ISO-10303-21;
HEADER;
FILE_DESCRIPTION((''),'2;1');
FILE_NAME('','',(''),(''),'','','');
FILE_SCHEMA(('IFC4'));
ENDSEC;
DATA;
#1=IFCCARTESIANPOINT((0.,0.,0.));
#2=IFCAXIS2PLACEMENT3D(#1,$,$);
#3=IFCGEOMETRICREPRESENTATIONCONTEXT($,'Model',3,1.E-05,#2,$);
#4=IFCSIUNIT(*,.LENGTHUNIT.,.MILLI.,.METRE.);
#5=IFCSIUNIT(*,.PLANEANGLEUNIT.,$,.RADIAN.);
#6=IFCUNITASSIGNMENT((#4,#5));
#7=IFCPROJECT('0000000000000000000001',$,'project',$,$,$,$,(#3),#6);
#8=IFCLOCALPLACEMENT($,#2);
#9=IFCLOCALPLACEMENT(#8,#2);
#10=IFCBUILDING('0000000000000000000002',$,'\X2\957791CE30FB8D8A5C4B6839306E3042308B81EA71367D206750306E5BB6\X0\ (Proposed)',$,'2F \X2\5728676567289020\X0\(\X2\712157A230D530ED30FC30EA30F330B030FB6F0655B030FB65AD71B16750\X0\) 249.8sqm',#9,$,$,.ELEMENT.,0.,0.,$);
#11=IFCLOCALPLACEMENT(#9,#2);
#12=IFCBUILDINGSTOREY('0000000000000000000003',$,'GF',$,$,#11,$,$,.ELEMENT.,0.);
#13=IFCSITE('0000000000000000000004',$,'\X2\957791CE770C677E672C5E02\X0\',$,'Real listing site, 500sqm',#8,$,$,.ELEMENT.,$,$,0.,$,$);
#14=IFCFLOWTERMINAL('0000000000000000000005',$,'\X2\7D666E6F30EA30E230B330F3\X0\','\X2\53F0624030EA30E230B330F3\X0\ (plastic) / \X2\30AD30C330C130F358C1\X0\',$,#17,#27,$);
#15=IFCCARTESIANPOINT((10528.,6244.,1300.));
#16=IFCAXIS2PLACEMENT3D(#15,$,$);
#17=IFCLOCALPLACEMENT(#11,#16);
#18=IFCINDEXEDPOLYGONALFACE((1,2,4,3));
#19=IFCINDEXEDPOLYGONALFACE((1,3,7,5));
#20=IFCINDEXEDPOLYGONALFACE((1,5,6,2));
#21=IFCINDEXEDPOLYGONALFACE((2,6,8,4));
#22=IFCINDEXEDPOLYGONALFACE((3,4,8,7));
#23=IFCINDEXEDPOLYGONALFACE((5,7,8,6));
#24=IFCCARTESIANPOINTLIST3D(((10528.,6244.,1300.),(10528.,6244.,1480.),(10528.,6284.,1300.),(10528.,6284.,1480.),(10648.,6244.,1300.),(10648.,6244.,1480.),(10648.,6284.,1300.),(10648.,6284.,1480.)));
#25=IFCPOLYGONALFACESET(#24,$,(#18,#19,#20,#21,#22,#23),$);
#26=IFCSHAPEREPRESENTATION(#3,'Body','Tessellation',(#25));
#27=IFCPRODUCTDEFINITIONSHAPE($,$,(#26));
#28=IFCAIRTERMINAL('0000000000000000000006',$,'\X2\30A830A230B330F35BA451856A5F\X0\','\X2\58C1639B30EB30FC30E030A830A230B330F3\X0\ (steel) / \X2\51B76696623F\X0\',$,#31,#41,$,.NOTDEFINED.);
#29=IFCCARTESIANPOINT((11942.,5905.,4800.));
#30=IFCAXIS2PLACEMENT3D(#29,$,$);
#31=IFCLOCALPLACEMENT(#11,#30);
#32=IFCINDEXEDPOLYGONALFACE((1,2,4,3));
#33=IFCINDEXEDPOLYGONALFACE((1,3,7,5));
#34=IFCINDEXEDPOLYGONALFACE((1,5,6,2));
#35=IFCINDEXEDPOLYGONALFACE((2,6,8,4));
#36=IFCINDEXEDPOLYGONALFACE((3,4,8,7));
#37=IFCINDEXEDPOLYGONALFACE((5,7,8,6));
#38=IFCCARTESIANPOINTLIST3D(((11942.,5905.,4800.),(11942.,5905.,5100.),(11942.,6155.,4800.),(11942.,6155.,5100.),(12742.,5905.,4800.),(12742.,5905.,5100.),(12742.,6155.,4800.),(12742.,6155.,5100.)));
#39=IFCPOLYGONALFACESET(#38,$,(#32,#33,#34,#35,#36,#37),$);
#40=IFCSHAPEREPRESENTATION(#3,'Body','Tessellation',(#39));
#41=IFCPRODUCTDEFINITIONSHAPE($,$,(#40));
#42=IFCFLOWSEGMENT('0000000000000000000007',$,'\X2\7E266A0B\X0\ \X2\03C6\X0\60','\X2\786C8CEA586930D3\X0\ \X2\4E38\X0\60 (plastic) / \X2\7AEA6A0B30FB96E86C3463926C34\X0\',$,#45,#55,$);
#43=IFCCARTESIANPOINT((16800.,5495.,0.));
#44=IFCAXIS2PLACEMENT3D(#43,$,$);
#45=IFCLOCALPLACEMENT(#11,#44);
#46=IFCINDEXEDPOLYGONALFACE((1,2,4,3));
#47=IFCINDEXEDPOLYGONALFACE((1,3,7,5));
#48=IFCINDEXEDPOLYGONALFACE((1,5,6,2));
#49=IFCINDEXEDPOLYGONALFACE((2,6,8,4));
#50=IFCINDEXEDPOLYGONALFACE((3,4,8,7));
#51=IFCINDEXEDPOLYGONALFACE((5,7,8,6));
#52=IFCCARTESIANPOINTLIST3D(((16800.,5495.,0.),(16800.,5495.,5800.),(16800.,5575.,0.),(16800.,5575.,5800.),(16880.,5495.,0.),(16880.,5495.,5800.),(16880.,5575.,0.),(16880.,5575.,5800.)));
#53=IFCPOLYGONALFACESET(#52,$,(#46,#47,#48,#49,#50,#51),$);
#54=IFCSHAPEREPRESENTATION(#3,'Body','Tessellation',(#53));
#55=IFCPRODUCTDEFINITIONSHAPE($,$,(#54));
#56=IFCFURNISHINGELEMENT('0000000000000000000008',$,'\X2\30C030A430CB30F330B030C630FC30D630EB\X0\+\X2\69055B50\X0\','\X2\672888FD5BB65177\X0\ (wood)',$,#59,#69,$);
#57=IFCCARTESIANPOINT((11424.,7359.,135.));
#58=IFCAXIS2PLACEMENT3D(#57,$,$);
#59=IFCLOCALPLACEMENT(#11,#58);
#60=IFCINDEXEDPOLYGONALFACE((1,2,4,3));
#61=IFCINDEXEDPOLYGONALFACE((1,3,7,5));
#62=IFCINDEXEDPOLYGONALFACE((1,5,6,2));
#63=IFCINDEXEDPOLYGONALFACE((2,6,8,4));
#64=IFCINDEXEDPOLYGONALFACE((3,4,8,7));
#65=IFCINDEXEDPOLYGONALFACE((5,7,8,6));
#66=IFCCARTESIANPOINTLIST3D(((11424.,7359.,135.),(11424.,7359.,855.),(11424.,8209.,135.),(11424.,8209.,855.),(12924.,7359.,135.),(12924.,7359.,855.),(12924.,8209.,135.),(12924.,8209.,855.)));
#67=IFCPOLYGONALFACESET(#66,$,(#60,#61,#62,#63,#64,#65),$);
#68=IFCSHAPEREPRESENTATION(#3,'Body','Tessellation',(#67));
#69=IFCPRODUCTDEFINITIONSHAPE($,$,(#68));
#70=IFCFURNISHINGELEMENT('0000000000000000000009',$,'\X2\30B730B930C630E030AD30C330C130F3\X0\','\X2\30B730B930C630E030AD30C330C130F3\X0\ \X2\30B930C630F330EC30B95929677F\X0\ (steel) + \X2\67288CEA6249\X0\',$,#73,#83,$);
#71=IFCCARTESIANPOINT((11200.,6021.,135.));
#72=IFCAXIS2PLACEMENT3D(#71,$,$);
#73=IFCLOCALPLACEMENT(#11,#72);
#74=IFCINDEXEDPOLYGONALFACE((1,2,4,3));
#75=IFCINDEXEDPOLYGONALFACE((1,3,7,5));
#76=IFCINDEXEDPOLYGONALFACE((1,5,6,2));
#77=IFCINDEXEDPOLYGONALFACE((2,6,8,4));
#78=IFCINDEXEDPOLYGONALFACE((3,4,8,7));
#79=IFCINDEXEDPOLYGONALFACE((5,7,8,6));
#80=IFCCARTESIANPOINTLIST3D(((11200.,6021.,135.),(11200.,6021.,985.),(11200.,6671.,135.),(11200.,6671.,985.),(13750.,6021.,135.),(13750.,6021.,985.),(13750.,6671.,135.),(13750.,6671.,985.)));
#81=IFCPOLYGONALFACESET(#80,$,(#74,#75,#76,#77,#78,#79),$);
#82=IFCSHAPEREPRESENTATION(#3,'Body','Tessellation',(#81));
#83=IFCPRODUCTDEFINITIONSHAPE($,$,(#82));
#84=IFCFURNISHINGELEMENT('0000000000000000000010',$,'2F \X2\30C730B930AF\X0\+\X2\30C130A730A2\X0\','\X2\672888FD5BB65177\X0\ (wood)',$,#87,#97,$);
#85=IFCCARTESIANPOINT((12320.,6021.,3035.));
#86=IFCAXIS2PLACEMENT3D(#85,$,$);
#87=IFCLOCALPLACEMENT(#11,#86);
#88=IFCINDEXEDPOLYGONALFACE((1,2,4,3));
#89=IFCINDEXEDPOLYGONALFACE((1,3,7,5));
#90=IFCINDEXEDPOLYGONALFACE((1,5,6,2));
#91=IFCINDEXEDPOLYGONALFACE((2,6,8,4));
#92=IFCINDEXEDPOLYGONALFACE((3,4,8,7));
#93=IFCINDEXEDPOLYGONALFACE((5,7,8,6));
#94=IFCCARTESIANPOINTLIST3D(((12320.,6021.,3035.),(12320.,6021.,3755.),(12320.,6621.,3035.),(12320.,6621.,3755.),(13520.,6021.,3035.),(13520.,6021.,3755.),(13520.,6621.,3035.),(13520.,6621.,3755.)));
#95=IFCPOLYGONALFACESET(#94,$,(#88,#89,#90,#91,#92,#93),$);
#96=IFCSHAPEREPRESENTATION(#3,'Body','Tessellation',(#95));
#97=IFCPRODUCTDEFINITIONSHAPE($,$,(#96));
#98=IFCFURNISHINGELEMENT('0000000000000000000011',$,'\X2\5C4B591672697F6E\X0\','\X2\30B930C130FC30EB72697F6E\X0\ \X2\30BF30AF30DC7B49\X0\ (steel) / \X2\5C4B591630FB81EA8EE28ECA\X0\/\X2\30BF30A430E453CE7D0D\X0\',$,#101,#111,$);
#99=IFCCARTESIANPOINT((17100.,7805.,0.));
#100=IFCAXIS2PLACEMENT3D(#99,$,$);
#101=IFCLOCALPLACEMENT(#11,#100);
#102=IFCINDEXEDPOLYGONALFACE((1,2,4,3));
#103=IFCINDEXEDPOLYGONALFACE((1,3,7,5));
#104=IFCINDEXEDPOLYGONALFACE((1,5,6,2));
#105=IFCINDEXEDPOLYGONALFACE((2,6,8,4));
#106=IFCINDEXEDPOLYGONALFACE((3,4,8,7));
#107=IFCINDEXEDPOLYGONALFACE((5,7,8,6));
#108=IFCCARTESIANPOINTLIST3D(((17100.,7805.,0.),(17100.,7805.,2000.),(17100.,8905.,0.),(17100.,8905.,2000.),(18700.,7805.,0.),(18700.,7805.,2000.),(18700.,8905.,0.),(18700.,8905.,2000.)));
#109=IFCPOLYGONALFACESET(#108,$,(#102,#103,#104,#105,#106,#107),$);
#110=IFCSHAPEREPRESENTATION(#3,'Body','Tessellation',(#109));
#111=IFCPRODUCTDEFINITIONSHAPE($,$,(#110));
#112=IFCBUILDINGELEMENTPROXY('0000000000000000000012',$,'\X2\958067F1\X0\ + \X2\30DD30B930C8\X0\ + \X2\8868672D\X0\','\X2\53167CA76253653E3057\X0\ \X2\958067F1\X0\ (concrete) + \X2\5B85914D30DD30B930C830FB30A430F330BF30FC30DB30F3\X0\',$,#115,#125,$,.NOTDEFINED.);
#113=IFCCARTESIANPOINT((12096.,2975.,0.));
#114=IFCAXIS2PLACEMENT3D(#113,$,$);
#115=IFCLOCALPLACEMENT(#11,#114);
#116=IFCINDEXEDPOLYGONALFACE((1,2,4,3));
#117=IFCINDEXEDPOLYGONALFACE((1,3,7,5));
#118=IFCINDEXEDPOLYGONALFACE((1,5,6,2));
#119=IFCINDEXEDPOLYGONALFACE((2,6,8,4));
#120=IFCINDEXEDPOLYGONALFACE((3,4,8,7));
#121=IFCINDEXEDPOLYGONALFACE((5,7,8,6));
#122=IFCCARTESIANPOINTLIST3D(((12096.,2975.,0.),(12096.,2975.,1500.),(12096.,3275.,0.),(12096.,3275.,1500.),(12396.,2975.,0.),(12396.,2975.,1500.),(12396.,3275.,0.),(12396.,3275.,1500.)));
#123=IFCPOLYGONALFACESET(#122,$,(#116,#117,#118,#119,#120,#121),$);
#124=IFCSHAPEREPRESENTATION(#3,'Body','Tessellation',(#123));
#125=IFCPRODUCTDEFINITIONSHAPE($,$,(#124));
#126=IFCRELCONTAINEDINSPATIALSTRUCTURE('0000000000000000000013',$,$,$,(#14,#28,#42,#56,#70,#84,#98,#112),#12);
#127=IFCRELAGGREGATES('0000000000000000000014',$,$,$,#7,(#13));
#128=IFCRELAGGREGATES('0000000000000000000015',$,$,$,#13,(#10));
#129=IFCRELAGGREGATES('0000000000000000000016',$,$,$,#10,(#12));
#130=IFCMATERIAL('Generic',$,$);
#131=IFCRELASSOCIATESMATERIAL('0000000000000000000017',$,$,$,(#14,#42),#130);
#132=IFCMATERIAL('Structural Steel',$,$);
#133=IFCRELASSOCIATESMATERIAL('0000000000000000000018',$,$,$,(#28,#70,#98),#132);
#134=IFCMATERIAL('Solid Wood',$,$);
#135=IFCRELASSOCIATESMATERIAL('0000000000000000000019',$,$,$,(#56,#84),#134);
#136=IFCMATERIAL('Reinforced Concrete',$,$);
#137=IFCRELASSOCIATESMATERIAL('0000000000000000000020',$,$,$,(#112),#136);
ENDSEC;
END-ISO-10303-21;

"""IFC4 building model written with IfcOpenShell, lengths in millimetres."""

from ifc_helpers import new_model, si_unit, frame, frame_2d, origin, place, context, project, spatial, rectangle, extrude, material, element, save


model = new_model("IFC4")

# Units and contexts
model_context = context("Model", 3, precision=1e-05, world=origin())
ifc_project = project(units=[si_unit("LENGTHUNIT", "METRE", prefix="MILLI"), si_unit("PLANEANGLEUNIT", "RADIAN")], contexts=[model_context])

# Site, building, storey
site_placement = place(None, origin())
site = spatial("IfcSite", under=ifc_project, at=site_placement, Name="長野県松本市", ObjectType="Real listing site, 500sqm", CompositionType="ELEMENT", RefElevation=0.0)
building_placement = place(site_placement, origin())
building = spatial("IfcBuilding", under=site, at=building_placement, Name="長野・越屋根のある自然素材の家 (Proposed)", ObjectType="2F 在来木造(無垢フローリング・漆喰・断熱材) 249.8sqm", CompositionType="ELEMENT", ElevationOfRefHeight=0.0, ElevationOfTerrain=0.0)
storey_placement = place(building_placement, origin())
storey = spatial("IfcBuildingStorey", under=building, at=storey_placement, Name="GF", CompositionType="ELEMENT", Elevation=0.0)

# Shared definitions
ifc_material_1 = material(Name="Solid Wood")

# Shared definitions
ifc_material_2 = material(Name="Reinforced Concrete")

# Shared definitions
ifc_material_3 = material(Name="Structural Steel")

# Flow terminal
ifc_material_4 = material(Name="Generic")
flow_terminal_1_placement = place(storey_placement, frame((10528.0, 6244.0, 1300.0)))
element("IfcFlowTerminal", 1, at=flow_terminal_1_placement, inside=storey, material=ifc_material_4, Name="給湯リモコン", Description="台所リモコン (plastic) / キッチン壁", context=model_context, shape_type="SweptSolid", body=[
    extrude(rectangle(XDim=120.0, YDim=40.0, at=frame_2d((60.0, 20.0))), frame((10528.0, 6244.0, 1300.0)), (0.0, 0.0, 1.0), 180.0),
])

# Air terminal
air_terminal_placement = place(storey_placement, frame((11942.0, 5905.0, 4800.0)))
element("IfcAirTerminal", 2, at=air_terminal_placement, inside=storey, material=ifc_material_3, Name="エアコン室内機", Description="壁掛ルームエアコン (steel) / 冷暖房", PredefinedType="NOTDEFINED", context=model_context, shape_type="SweptSolid", body=[
    extrude(rectangle(XDim=800.0, YDim=250.0, at=frame_2d((400.0, 125.0))), frame((11942.0, 5905.0, 4800.0)), (0.0, 0.0, 1.0), 300.0),
])

# Flow segment
flow_segment_placement = place(storey_placement, frame((16800.0, 5495.0, 0.0)))
element("IfcFlowSegment", 3, at=flow_segment_placement, inside=storey, material=ifc_material_4, Name="縦樋 φ60", Description="硬質塩ビ 丸60 (plastic) / 竪樋・雨水排水", context=model_context, shape_type="SweptSolid", body=[
    extrude(rectangle(XDim=80.0, YDim=80.0, at=frame_2d((40.0, 40.0))), frame((16800.0, 5495.0, 0.0)), (0.0, 0.0, 1.0), 5800.0),
])

# Furnishing elements
furnishing_1_placement = place(storey_placement, frame((11424.0, 7359.0, 135.0)))
element("IfcFurnishingElement", 4, at=furnishing_1_placement, inside=storey, material=ifc_material_1, Name="ダイニングテーブル+椅子", Description="木製家具 (wood)", context=model_context, shape_type="SweptSolid", body=[
    extrude(rectangle(XDim=1500.0, YDim=850.0, at=frame_2d((750.0, 425.0))), frame((11424.0, 7359.0, 135.0)), (0.0, 0.0, 1.0), 720.0),
])
furnishing_2_placement = place(storey_placement, frame((11200.0, 6021.0, 135.0)))
element("IfcFurnishingElement", 5, at=furnishing_2_placement, inside=storey, material=ifc_material_3, Name="システムキッチン", Description="システムキッチン ステンレス天板 (steel) + 木質扉", context=model_context, shape_type="SweptSolid", body=[
    extrude(rectangle(XDim=2550.0, YDim=650.0, at=frame_2d((1275.0, 325.0))), frame((11200.0, 6021.0, 135.0)), (0.0, 0.0, 1.0), 850.0),
])
furnishing_3_placement = place(storey_placement, frame((12320.0, 6021.0, 3035.0)))
element("IfcFurnishingElement", 6, at=furnishing_3_placement, inside=storey, material=ifc_material_1, Name="2F デスク+チェア", Description="木製家具 (wood)", context=model_context, shape_type="SweptSolid", body=[
    extrude(rectangle(XDim=1200.0, YDim=600.0, at=frame_2d((600.0, 300.0))), frame((12320.0, 6021.0, 3035.0)), (0.0, 0.0, 1.0), 720.0),
])
furnishing_4_placement = place(storey_placement, frame((17100.0, 7805.0, 0.0)))
element("IfcFurnishingElement", 7, at=furnishing_4_placement, inside=storey, material=ifc_material_3, Name="屋外物置", Description="スチール物置 タクボ等 (steel) / 屋外・自転車/タイヤ収納", context=model_context, shape_type="SweptSolid", body=[
    extrude(rectangle(XDim=1600.0, YDim=1100.0, at=frame_2d((800.0, 550.0))), frame((17100.0, 7805.0, 0.0)), (0.0, 0.0, 1.0), 2000.0),
])

# Building element proxy
proxy_placement = place(storey_placement, frame((12096.0, 2975.0, 0.0)))
element("IfcBuildingElementProxy", 8, at=proxy_placement, inside=storey, material=ifc_material_2, Name="門柱 + ポスト + 表札", Description="化粧打放し 門柱 (concrete) + 宅配ポスト・インターホン", PredefinedType="NOTDEFINED", context=model_context, shape_type="SweptSolid", body=[
    extrude(rectangle(XDim=300.0, YDim=300.0, at=frame_2d((150.0, 150.0))), frame((12096.0, 2975.0, 0.0)), (0.0, 0.0, 1.0), 1500.0),
])

save(model, "model.ifc")
